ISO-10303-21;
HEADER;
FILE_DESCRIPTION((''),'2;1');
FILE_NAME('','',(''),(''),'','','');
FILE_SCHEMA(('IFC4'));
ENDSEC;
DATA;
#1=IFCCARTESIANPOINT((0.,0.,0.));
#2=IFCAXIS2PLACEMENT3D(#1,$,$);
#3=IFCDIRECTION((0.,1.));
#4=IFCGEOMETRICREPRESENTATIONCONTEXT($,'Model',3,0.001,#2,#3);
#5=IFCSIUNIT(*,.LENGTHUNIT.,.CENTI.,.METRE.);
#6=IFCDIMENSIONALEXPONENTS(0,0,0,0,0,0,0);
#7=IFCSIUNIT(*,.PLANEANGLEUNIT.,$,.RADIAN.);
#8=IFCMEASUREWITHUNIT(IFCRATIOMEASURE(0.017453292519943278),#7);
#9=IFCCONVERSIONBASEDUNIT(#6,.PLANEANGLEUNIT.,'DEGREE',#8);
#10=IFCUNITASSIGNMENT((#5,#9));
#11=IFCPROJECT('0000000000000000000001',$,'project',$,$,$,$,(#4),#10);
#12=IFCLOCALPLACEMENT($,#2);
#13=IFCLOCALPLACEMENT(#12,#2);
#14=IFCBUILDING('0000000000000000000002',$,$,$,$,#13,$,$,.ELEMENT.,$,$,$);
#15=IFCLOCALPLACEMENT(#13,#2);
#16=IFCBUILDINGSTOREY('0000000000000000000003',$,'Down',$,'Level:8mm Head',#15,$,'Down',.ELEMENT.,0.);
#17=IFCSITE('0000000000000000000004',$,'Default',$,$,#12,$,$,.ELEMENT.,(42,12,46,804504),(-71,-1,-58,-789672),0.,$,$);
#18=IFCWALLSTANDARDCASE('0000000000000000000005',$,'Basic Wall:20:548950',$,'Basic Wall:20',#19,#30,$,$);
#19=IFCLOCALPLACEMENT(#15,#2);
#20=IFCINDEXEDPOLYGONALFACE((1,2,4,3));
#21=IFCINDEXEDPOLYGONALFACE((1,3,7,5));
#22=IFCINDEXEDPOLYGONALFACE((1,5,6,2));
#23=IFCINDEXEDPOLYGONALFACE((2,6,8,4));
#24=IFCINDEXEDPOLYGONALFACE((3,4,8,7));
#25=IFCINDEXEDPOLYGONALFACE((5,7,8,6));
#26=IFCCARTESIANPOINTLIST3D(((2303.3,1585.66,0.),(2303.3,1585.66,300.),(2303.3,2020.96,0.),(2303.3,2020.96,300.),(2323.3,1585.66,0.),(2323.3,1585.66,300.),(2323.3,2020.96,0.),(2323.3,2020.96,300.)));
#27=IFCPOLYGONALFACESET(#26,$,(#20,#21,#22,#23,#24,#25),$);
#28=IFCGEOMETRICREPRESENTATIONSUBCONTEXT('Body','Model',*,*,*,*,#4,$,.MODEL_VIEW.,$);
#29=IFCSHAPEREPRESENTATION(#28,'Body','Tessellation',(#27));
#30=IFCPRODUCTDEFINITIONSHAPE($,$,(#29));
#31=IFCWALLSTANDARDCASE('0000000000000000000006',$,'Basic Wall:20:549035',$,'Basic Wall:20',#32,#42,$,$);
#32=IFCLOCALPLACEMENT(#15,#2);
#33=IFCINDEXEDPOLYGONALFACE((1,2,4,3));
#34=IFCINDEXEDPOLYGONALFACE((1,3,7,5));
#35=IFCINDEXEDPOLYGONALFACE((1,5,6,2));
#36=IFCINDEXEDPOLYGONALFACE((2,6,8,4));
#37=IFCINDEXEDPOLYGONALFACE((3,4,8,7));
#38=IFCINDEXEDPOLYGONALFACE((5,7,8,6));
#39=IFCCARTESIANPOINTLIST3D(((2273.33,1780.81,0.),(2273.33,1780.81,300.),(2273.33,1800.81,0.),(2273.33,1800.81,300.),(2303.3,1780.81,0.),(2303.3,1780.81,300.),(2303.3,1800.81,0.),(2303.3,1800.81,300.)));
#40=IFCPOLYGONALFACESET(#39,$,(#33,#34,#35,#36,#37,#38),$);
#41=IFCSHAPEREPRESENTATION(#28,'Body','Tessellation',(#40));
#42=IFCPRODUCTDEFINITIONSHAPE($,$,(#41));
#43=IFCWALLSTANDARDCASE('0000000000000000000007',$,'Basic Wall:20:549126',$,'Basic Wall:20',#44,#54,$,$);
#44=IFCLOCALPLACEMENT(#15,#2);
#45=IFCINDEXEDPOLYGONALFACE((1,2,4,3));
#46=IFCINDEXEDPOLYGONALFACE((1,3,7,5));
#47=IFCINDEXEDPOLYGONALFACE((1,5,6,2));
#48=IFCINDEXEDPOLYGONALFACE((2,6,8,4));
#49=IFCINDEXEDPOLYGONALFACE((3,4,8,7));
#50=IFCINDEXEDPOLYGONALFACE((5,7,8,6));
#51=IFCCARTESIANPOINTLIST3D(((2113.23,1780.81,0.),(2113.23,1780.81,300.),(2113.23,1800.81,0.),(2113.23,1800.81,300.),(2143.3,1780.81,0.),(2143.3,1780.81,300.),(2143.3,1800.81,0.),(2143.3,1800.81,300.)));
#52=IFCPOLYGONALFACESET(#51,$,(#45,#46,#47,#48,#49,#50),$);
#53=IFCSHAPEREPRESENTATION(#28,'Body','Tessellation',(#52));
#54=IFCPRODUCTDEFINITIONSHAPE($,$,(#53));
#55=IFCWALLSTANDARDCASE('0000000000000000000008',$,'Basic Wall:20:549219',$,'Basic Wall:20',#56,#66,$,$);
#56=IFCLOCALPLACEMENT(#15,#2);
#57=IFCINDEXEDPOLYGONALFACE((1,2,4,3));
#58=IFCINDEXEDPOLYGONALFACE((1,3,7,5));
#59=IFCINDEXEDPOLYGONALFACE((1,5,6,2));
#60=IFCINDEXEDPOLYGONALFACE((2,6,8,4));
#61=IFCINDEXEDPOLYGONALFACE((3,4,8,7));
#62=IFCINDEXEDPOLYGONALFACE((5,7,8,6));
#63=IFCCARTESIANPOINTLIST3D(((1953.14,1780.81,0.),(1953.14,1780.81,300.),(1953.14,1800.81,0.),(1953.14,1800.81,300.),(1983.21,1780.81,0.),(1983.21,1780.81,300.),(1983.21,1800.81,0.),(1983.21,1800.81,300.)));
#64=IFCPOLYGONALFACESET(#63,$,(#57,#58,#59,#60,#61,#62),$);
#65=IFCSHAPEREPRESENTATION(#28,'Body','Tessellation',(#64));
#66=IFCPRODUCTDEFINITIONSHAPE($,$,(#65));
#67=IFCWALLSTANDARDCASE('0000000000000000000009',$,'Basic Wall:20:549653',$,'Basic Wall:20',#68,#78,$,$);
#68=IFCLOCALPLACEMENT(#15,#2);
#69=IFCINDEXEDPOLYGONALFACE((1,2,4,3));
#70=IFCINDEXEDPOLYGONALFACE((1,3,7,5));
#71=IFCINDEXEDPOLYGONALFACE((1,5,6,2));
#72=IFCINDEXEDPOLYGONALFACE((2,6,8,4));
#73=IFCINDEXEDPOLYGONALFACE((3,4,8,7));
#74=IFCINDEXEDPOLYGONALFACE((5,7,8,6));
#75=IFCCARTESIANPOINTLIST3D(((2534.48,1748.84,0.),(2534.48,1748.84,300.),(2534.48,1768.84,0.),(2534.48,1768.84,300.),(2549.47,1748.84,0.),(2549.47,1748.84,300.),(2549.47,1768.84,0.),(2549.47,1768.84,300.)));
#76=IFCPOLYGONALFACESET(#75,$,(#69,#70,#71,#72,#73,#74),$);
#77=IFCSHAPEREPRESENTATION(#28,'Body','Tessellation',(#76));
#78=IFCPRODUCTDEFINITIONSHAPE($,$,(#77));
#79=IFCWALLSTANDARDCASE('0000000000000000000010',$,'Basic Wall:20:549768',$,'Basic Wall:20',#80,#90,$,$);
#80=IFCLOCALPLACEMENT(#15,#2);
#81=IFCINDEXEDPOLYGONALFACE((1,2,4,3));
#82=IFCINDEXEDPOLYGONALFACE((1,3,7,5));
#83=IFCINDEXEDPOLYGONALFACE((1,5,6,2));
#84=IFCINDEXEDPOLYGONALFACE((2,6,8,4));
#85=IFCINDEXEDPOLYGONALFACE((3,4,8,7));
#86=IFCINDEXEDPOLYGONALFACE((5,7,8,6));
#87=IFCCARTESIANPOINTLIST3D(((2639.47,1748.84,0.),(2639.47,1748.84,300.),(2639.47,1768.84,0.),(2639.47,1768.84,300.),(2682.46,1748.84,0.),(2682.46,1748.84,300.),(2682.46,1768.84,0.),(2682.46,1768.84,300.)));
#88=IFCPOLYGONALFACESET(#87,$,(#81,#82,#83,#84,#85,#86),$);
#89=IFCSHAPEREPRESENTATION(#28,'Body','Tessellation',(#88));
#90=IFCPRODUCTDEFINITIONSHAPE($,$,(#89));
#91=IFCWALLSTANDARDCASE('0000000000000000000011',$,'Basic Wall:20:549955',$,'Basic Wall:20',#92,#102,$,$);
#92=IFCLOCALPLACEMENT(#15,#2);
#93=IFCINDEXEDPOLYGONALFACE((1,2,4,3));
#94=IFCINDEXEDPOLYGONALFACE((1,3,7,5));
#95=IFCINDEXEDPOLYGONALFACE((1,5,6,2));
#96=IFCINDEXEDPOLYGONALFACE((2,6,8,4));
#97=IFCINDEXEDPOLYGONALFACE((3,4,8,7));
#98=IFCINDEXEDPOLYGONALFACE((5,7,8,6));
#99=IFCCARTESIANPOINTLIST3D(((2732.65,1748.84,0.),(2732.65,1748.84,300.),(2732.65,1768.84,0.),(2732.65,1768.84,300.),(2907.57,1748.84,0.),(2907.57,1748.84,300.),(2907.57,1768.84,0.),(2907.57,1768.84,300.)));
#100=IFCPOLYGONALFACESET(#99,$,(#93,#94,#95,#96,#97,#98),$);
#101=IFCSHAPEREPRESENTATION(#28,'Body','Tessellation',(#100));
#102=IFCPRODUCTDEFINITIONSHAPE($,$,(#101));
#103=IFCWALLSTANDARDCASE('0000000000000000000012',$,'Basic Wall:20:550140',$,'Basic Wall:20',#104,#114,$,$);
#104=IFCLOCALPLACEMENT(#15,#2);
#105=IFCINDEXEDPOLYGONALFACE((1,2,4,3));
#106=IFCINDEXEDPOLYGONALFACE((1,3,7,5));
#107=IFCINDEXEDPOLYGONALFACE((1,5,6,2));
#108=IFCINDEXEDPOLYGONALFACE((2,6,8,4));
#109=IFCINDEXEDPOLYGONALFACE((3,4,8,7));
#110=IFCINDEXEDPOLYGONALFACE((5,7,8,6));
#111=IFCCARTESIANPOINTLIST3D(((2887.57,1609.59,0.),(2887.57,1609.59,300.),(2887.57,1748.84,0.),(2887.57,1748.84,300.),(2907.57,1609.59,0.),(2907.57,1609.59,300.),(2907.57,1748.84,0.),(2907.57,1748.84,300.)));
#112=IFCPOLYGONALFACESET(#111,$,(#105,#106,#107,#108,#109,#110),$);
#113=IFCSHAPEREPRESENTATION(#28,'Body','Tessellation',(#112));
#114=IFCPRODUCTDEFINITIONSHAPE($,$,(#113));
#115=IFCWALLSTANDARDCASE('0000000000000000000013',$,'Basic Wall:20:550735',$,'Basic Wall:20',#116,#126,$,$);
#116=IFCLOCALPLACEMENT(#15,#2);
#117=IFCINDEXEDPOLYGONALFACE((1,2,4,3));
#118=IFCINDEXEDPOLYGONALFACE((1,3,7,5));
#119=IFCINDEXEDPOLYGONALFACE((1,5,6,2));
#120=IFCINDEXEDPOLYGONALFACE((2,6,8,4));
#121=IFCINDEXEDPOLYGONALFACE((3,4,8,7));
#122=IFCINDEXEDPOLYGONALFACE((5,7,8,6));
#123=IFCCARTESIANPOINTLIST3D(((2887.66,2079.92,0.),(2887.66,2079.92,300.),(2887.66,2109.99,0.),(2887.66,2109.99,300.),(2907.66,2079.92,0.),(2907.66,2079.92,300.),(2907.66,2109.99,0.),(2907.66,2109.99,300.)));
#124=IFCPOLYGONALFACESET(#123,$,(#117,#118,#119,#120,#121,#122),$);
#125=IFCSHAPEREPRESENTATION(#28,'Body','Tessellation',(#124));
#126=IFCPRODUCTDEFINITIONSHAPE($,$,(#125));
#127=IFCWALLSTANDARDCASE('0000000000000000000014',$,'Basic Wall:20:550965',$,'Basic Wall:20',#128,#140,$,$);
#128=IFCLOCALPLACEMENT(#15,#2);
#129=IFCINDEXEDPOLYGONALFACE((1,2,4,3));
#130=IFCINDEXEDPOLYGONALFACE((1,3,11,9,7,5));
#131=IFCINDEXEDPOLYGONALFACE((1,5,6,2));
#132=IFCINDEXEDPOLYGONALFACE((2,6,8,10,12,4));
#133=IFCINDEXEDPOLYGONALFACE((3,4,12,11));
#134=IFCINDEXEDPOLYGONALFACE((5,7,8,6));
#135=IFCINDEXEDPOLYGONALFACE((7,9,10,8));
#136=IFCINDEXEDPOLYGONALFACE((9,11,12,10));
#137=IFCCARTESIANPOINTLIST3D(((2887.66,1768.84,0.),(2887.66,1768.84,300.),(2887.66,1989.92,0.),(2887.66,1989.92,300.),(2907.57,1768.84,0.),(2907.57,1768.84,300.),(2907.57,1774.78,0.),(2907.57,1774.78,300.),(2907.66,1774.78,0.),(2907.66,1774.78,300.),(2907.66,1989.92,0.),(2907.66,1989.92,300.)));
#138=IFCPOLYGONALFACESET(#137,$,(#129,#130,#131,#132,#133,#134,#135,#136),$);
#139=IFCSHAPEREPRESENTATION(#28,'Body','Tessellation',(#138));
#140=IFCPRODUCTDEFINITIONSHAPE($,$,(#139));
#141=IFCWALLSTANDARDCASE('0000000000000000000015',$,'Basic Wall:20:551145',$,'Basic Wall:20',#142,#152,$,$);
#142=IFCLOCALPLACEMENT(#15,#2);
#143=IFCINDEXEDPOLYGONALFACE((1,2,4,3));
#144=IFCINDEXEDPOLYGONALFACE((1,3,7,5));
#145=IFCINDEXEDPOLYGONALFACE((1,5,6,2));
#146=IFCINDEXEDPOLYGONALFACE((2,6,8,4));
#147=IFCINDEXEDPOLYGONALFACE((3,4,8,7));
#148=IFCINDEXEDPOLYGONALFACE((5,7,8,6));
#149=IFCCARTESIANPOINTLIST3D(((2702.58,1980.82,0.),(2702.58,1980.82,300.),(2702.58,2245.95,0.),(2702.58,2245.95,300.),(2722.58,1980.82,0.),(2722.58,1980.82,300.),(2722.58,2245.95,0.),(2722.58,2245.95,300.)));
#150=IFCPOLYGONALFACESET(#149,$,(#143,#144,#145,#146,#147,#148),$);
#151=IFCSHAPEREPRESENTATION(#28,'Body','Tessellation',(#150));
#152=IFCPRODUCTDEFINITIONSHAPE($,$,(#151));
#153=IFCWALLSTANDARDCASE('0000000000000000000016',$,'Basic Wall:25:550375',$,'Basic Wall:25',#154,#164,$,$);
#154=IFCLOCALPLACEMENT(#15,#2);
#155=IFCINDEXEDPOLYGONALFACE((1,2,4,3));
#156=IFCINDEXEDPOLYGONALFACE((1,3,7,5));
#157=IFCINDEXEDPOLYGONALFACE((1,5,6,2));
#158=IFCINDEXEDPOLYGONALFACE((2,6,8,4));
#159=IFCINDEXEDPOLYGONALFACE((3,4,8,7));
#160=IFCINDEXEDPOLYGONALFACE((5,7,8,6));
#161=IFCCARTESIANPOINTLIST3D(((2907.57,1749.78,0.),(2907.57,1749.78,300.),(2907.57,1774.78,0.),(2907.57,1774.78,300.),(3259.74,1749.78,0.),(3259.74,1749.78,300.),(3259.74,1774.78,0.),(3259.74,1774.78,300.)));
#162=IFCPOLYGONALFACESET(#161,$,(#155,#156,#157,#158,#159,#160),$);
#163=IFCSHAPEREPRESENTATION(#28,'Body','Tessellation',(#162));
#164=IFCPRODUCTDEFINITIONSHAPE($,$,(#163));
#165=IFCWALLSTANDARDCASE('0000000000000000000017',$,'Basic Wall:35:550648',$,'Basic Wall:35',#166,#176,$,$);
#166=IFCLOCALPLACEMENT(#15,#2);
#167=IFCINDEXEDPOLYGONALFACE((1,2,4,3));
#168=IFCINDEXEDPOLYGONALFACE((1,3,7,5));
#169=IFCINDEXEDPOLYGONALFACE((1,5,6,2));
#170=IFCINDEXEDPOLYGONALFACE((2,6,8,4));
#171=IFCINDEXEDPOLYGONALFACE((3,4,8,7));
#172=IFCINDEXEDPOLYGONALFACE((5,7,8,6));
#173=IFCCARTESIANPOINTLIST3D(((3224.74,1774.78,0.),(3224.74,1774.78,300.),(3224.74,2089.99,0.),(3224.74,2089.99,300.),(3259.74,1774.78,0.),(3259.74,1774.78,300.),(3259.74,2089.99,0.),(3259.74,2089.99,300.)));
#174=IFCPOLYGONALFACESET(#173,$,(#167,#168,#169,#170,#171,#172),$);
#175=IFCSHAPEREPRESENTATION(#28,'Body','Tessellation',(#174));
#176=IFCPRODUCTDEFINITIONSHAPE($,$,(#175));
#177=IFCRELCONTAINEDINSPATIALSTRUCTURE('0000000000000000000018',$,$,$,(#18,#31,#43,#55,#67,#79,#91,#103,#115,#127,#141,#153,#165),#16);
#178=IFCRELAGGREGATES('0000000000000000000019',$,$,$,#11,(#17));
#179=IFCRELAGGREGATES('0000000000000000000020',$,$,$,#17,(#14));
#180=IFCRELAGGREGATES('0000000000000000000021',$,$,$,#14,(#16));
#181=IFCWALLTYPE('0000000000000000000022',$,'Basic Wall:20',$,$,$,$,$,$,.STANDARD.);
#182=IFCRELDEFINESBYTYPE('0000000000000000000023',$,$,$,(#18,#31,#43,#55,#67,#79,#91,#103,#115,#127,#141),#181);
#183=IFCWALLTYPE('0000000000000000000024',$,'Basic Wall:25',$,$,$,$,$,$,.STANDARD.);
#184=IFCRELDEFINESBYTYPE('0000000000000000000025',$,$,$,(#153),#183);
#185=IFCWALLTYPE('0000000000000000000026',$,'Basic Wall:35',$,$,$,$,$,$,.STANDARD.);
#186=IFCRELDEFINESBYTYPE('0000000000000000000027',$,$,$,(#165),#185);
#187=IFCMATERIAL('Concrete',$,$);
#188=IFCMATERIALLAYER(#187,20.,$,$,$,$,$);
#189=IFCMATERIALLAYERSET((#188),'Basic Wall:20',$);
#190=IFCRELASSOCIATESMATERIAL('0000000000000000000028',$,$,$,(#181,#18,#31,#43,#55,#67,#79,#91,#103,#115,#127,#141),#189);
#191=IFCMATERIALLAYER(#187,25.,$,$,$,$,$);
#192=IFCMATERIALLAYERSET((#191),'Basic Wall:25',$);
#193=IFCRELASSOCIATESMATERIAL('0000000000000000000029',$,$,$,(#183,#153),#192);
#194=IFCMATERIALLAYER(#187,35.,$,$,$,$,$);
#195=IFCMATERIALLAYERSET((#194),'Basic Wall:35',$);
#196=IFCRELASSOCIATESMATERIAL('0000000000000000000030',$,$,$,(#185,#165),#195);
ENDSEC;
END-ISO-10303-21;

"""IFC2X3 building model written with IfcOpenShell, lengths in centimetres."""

from ifc_helpers import new_model, entity, si_unit, converted_unit, direction, frame, frame_2d, origin, place, context, subcontext, project, spatial, polyline, rectangle, outline, extrude, material, layer, layer_set, layer_usage, type_object, element, save


model = new_model("IFC2X3")

# Units and contexts
model_context = context("Model", 3, precision=0.001, world=origin(), true_north=direction((0.0, 1.0)))
body_context = subcontext(model_context, "Body", "Model", "MODEL_VIEW")
ifc_project = project(units=[si_unit("LENGTHUNIT", "METRE", prefix="CENTI"), converted_unit("PLANEANGLEUNIT", "DEGREE", entity("IfcRatioMeasure", 0.017453292519943278), si_unit("PLANEANGLEUNIT", "RADIAN"), dimensions=[0, 0, 0, 0, 0, 0, 0])], contexts=[model_context])

# Site, building, storey
site_placement = place(None, origin())
site = spatial("IfcSite", under=ifc_project, at=site_placement, Name="Default", CompositionType="ELEMENT", RefLatitude=(42, 12, 46, 804504), RefLongitude=(-71, -1, -58, -789672), RefElevation=0.0)
building_placement = place(site_placement, origin())
building = spatial("IfcBuilding", under=site, at=building_placement, CompositionType="ELEMENT")
storey_placement = place(building_placement, origin())
storey = spatial("IfcBuildingStorey", under=building, at=storey_placement, Name="Down", ObjectType="Level:8mm Head", LongName="Down", CompositionType="ELEMENT", Elevation=0.0)

# Walls
ifc_material = material(Name="Concrete")
ifc_layer_1 = layer(ifc_material, 20.0)
ifc_layer_set_1 = layer_set([ifc_layer_1], Name="Basic Wall:20")
wall_type_1 = type_object("IfcWallType", Name="Basic Wall:20", PredefinedType="STANDARD", material=ifc_layer_set_1)
ifc_layer_usage_1 = layer_usage(ifc_layer_set_1, "AXIS2", "POSITIVE", -10.0)
wall_1_placement = place(storey_placement, frame((2313.3, 1585.66, 0.0), z_axis=(0.0, 0.0, 1.0), x_axis=(0.0, 1.0, 0.0)))
element("IfcWallStandardCase", 1, at=wall_1_placement, inside=storey, type_object=wall_type_1, material=ifc_layer_usage_1, Name="Basic Wall:20:548950", ObjectType="Basic Wall:20", context=body_context, shape_type="SweptSolid", body=[
    extrude(rectangle(XDim=435.3, YDim=20.0, at=frame_2d((217.65, 0.0), x_axis=(-1.0, 0.0))), origin(), (0.0, 0.0, 1.0), 300.0),
])
ifc_layer_usage_2 = layer_usage(ifc_layer_set_1, "AXIS2", "POSITIVE", -10.0)
wall_2_placement = place(storey_placement, frame((2303.3, 1790.81, 0.0), z_axis=(0.0, 0.0, 1.0), x_axis=(-1.0, 0.0, 0.0)))
element("IfcWallStandardCase", 2, at=wall_2_placement, inside=storey, type_object=wall_type_1, material=ifc_layer_usage_2, Name="Basic Wall:20:549035", ObjectType="Basic Wall:20", context=body_context, shape_type="SweptSolid", body=[
    extrude(rectangle(XDim=29.98, YDim=20.0, at=frame_2d((14.99, 0.0), x_axis=(-1.0, 0.0))), origin(), (0.0, 0.0, 1.0), 300.0),
])
ifc_layer_usage_3 = layer_usage(ifc_layer_set_1, "AXIS2", "POSITIVE", -10.0)
wall_3_placement = place(storey_placement, frame((2143.3, 1790.81, 0.0), z_axis=(0.0, 0.0, 1.0), x_axis=(-1.0, 0.0, 0.0)))
element("IfcWallStandardCase", 3, at=wall_3_placement, inside=storey, type_object=wall_type_1, material=ifc_layer_usage_3, Name="Basic Wall:20:549126", ObjectType="Basic Wall:20", context=body_context, shape_type="SweptSolid", body=[
    extrude(rectangle(XDim=30.07, YDim=20.0, at=frame_2d((15.04, 0.0), x_axis=(-1.0, 0.0))), origin(), (0.0, 0.0, 1.0), 300.0),
])
ifc_layer_usage_4 = layer_usage(ifc_layer_set_1, "AXIS2", "POSITIVE", -10.0)
wall_4_placement = place(storey_placement, frame((1983.21, 1790.81, 0.0), z_axis=(0.0, 0.0, 1.0), x_axis=(-1.0, 0.0, 0.0)))
element("IfcWallStandardCase", 4, at=wall_4_placement, inside=storey, type_object=wall_type_1, material=ifc_layer_usage_4, Name="Basic Wall:20:549219", ObjectType="Basic Wall:20", context=body_context, shape_type="SweptSolid", body=[
    extrude(rectangle(XDim=30.07, YDim=20.0, at=frame_2d((15.04, 0.0), x_axis=(-1.0, 0.0))), origin(), (0.0, 0.0, 1.0), 300.0),
])
ifc_layer_usage_5 = layer_usage(ifc_layer_set_1, "AXIS2", "NEGATIVE", 10.0)
wall_5_placement = place(storey_placement, frame((2534.48, 1758.84, 0.0)))
element("IfcWallStandardCase", 5, at=wall_5_placement, inside=storey, type_object=wall_type_1, material=ifc_layer_usage_5, Name="Basic Wall:20:549653", ObjectType="Basic Wall:20", context=body_context, shape_type="SweptSolid", body=[
    extrude(rectangle(XDim=14.99, YDim=20.0, at=frame_2d((7.49, 0.0), x_axis=(-1.0, 0.0))), origin(), (0.0, 0.0, 1.0), 300.0),
])
ifc_layer_usage_6 = layer_usage(ifc_layer_set_1, "AXIS2", "NEGATIVE", 10.0)
wall_6_placement = place(storey_placement, frame((2639.47, 1758.84, 0.0)))
element("IfcWallStandardCase", 6, at=wall_6_placement, inside=storey, type_object=wall_type_1, material=ifc_layer_usage_6, Name="Basic Wall:20:549768", ObjectType="Basic Wall:20", context=body_context, shape_type="SweptSolid", body=[
    extrude(rectangle(XDim=42.99, YDim=20.0, at=frame_2d((21.49, 0.0), x_axis=(-1.0, 0.0))), origin(), (0.0, 0.0, 1.0), 300.0),
])
ifc_layer_usage_7 = layer_usage(ifc_layer_set_1, "AXIS2", "NEGATIVE", 10.0)
wall_7_placement = place(storey_placement, frame((2732.65, 1758.84, 0.0)))
element("IfcWallStandardCase", 7, at=wall_7_placement, inside=storey, type_object=wall_type_1, material=ifc_layer_usage_7, Name="Basic Wall:20:549955", ObjectType="Basic Wall:20", context=body_context, shape_type="SweptSolid", body=[
    extrude(rectangle(XDim=174.92, YDim=20.0, at=frame_2d((87.46, 0.0), x_axis=(-1.0, 0.0))), origin(), (0.0, 0.0, 1.0), 300.0),
])
ifc_layer_usage_8 = layer_usage(ifc_layer_set_1, "AXIS2", "NEGATIVE", 10.0)
wall_8_placement = place(storey_placement, frame((2897.57, 1748.84, 0.0), z_axis=(0.0, 0.0, 1.0), x_axis=(0.0, -1.0, 0.0)))
element("IfcWallStandardCase", 8, at=wall_8_placement, inside=storey, type_object=wall_type_1, material=ifc_layer_usage_8, Name="Basic Wall:20:550140", ObjectType="Basic Wall:20", context=body_context, shape_type="SweptSolid", body=[
    extrude(rectangle(XDim=139.25, YDim=20.0, at=frame_2d((69.62, 0.0), x_axis=(-1.0, 0.0))), origin(), (0.0, 0.0, 1.0), 300.0),
])
ifc_layer_usage_9 = layer_usage(ifc_layer_set_1, "AXIS2", "POSITIVE", -10.0)
wall_9_placement = place(storey_placement, frame((2897.66, 2109.99, 0.0), z_axis=(0.0, 0.0, 1.0), x_axis=(0.0, -1.0, 0.0)))
element("IfcWallStandardCase", 9, at=wall_9_placement, inside=storey, type_object=wall_type_1, material=ifc_layer_usage_9, Name="Basic Wall:20:550735", ObjectType="Basic Wall:20", context=body_context, shape_type="SweptSolid", body=[
    extrude(rectangle(XDim=30.07, YDim=20.0, at=frame_2d((15.04, 0.0), x_axis=(-1.0, 0.0))), origin(), (0.0, 0.0, 1.0), 300.0),
])
ifc_layer_usage_10 = layer_usage(ifc_layer_set_1, "AXIS2", "POSITIVE", -10.0)
wall_10_placement = place(storey_placement, frame((2897.66, 1989.92, 0.0), z_axis=(0.0, 0.0, 1.0), x_axis=(0.0, -1.0, 0.0)))
element("IfcWallStandardCase", 10, at=wall_10_placement, inside=storey, type_object=wall_type_1, material=ifc_layer_usage_10, Name="Basic Wall:20:550965", ObjectType="Basic Wall:20", context=body_context, shape_type="SweptSolid", body=[
    extrude(outline(polyline([(221.08, -10.0), (221.08, 9.91), (215.14, 9.91), (215.14, 10.0), (0.0, 10.0), (0.0, -10.0), (221.08, -10.0)])), origin(), (0.0, 0.0, 1.0), 300.0),
])
ifc_layer_usage_11 = layer_usage(ifc_layer_set_1, "AXIS2", "NEGATIVE", 10.0)
wall_11_placement = place(storey_placement, frame((2712.58, 1980.82, 0.0), z_axis=(0.0, 0.0, 1.0), x_axis=(0.0, 1.0, 0.0)))
element("IfcWallStandardCase", 11, at=wall_11_placement, inside=storey, type_object=wall_type_1, material=ifc_layer_usage_11, Name="Basic Wall:20:551145", ObjectType="Basic Wall:20", context=body_context, shape_type="SweptSolid", body=[
    extrude(rectangle(XDim=265.13, YDim=20.0, at=frame_2d((132.57, 0.0), x_axis=(-1.0, 0.0))), origin(), (0.0, 0.0, 1.0), 300.0),
])
ifc_layer_2 = layer(ifc_material, 25.0)
ifc_layer_set_2 = layer_set([ifc_layer_2], Name="Basic Wall:25")
ifc_layer_usage_12 = layer_usage(ifc_layer_set_2, "AXIS2", "POSITIVE", -12.5)
wall_type_2 = type_object("IfcWallType", Name="Basic Wall:25", PredefinedType="STANDARD", material=ifc_layer_set_2)
wall_12_placement = place(storey_placement, frame((2907.57, 1762.28, 0.0)))
element("IfcWallStandardCase", 12, at=wall_12_placement, inside=storey, type_object=wall_type_2, material=ifc_layer_usage_12, Name="Basic Wall:25:550375", ObjectType="Basic Wall:25", context=body_context, shape_type="SweptSolid", body=[
    extrude(rectangle(XDim=352.17, YDim=25.0, at=frame_2d((176.08, 0.0), x_axis=(-1.0, 0.0))), origin(), (0.0, 0.0, 1.0), 300.0),
])
ifc_layer_3 = layer(ifc_material, 35.0)
ifc_layer_set_3 = layer_set([ifc_layer_3], Name="Basic Wall:35")
ifc_layer_usage_13 = layer_usage(ifc_layer_set_3, "AXIS2", "POSITIVE", -17.5)
wall_type_3 = type_object("IfcWallType", Name="Basic Wall:35", PredefinedType="STANDARD", material=ifc_layer_set_3)
wall_13_placement = place(storey_placement, frame((3242.24, 1774.78, 0.0), z_axis=(0.0, 0.0, 1.0), x_axis=(0.0, 1.0, 0.0)))
element("IfcWallStandardCase", 13, at=wall_13_placement, inside=storey, type_object=wall_type_3, material=ifc_layer_usage_13, Name="Basic Wall:35:550648", ObjectType="Basic Wall:35", context=body_context, shape_type="SweptSolid", body=[
    extrude(rectangle(XDim=315.22, YDim=35.0, at=frame_2d((157.61, 0.0), x_axis=(-1.0, 0.0))), origin(), (0.0, 0.0, 1.0), 300.0),
])

save(model, "model.ifc")
